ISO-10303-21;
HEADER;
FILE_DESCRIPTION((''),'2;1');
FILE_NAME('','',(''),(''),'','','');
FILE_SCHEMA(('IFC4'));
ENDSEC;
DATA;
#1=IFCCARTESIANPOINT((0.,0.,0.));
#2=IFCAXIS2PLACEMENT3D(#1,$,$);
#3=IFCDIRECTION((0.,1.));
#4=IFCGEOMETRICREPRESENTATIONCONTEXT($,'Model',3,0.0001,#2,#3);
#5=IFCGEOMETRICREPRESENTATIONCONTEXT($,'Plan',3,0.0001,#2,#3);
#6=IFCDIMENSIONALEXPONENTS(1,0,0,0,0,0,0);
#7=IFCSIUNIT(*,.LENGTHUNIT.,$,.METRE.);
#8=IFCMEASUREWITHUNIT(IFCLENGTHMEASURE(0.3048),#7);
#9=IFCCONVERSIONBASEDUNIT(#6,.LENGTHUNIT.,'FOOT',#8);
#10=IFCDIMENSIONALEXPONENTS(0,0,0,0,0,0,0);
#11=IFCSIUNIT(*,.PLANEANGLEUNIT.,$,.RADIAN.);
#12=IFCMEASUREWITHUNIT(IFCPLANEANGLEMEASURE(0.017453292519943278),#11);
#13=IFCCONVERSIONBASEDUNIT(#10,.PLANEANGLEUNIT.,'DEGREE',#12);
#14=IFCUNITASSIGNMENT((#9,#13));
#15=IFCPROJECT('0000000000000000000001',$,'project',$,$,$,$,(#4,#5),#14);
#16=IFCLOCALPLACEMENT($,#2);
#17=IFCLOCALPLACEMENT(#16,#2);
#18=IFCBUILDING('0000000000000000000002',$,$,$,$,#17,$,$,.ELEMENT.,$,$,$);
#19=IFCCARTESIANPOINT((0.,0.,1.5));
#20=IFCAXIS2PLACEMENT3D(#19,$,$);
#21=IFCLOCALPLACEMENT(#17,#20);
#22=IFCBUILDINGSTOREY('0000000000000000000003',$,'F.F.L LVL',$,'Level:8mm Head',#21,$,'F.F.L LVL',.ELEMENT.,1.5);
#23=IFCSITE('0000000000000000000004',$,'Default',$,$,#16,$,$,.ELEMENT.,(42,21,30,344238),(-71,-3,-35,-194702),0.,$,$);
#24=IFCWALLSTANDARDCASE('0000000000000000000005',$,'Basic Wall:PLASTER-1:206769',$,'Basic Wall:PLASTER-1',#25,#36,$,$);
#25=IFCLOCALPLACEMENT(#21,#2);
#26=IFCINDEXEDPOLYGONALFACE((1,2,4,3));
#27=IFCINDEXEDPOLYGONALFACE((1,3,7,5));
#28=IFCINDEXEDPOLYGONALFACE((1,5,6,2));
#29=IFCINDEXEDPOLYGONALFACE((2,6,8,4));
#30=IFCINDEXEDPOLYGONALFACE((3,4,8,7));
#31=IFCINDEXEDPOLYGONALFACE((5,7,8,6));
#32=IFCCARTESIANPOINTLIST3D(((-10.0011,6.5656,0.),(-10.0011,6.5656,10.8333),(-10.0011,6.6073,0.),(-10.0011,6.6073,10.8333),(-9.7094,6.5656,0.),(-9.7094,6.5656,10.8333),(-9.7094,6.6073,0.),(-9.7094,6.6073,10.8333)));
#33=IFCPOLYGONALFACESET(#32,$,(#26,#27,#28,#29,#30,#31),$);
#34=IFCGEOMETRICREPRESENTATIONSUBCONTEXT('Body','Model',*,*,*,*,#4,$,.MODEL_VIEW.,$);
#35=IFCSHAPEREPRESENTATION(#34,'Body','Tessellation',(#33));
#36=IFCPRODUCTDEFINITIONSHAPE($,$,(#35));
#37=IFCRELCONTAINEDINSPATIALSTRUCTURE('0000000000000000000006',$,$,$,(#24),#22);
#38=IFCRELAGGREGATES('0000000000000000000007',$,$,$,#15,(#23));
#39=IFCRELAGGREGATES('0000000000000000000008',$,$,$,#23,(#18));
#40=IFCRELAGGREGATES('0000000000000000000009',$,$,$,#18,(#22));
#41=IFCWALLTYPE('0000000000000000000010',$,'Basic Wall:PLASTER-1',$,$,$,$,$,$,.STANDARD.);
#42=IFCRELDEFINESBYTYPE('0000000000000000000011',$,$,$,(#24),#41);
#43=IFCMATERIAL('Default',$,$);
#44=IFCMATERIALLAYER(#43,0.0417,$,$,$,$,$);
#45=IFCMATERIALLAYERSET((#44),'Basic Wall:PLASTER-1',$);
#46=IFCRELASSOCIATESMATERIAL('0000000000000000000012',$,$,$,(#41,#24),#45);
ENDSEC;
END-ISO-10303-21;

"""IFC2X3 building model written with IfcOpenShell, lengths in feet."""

from ifc_helpers import new_model, entity, si_unit, converted_unit, direction, frame, frame_2d, origin, place, context, subcontext, project, spatial, rectangle, extrude, material, layer, layer_set, layer_usage, type_object, element, save


model = new_model("IFC2X3")

# Units and contexts
model_context = context("Model", 3, precision=0.0001, world=origin(), true_north=direction((0.0, 1.0)))
plan_context = context("Plan", 3, precision=0.0001, world=origin(), true_north=direction((0.0, 1.0)))
body_context = subcontext(model_context, "Body", "Model", "MODEL_VIEW")
ifc_project = project(units=[converted_unit("LENGTHUNIT", "FOOT", entity("IfcLengthMeasure", 0.3048), si_unit("LENGTHUNIT", "METRE"), dimensions=[1, 0, 0, 0, 0, 0, 0]), converted_unit("PLANEANGLEUNIT", "DEGREE", entity("IfcPlaneAngleMeasure", 0.017453292519943278), si_unit("PLANEANGLEUNIT", "RADIAN"), dimensions=[0, 0, 0, 0, 0, 0, 0])], contexts=[model_context, plan_context])

# Site, building, storey
site_placement = place(None, origin())
site = spatial("IfcSite", under=ifc_project, at=site_placement, Name="Default", CompositionType="ELEMENT", RefLatitude=(42, 21, 30, 344238), RefLongitude=(-71, -3, -35, -194702), RefElevation=0.0)
building_placement = place(site_placement, origin())
building = spatial("IfcBuilding", under=site, at=building_placement, CompositionType="ELEMENT")
storey_placement = place(building_placement, frame((0.0, 0.0, 1.5)))
storey = spatial("IfcBuildingStorey", under=building, at=storey_placement, Name="F.F.L LVL", ObjectType="Level:8mm Head", LongName="F.F.L LVL", CompositionType="ELEMENT", Elevation=1.5)

# Wall
ifc_material_1 = material(Name="Default")
ifc_layer_1 = layer(ifc_material_1, 0.0417)
ifc_layer_set_1 = layer_set([ifc_layer_1], Name="Basic Wall:PLASTER-1")
wall_type_1 = type_object("IfcWallType", Name="Basic Wall:PLASTER-1", PredefinedType="STANDARD", material=ifc_layer_set_1)
ifc_layer_usage_1 = layer_usage(ifc_layer_set_1, "AXIS2", "NEGATIVE", 0.0208)
wall_1_placement = place(storey_placement, frame((-10.0011, 6.5864, 0.0)))
element("IfcWallStandardCase", 1, at=wall_1_placement, inside=storey, type_object=wall_type_1, material=ifc_layer_usage_1, Name="Basic Wall:PLASTER-1:206769", ObjectType="Basic Wall:PLASTER-1", context=body_context, shape_type="SweptSolid", body=[
    extrude(rectangle(XDim=0.2917, YDim=0.0417, at=frame_2d((0.1458, 0.0), x_axis=(-1.0, 0.0))), origin(), (0.0, 0.0, 1.0), 10.8333),
])

save(model, "model.ifc")
